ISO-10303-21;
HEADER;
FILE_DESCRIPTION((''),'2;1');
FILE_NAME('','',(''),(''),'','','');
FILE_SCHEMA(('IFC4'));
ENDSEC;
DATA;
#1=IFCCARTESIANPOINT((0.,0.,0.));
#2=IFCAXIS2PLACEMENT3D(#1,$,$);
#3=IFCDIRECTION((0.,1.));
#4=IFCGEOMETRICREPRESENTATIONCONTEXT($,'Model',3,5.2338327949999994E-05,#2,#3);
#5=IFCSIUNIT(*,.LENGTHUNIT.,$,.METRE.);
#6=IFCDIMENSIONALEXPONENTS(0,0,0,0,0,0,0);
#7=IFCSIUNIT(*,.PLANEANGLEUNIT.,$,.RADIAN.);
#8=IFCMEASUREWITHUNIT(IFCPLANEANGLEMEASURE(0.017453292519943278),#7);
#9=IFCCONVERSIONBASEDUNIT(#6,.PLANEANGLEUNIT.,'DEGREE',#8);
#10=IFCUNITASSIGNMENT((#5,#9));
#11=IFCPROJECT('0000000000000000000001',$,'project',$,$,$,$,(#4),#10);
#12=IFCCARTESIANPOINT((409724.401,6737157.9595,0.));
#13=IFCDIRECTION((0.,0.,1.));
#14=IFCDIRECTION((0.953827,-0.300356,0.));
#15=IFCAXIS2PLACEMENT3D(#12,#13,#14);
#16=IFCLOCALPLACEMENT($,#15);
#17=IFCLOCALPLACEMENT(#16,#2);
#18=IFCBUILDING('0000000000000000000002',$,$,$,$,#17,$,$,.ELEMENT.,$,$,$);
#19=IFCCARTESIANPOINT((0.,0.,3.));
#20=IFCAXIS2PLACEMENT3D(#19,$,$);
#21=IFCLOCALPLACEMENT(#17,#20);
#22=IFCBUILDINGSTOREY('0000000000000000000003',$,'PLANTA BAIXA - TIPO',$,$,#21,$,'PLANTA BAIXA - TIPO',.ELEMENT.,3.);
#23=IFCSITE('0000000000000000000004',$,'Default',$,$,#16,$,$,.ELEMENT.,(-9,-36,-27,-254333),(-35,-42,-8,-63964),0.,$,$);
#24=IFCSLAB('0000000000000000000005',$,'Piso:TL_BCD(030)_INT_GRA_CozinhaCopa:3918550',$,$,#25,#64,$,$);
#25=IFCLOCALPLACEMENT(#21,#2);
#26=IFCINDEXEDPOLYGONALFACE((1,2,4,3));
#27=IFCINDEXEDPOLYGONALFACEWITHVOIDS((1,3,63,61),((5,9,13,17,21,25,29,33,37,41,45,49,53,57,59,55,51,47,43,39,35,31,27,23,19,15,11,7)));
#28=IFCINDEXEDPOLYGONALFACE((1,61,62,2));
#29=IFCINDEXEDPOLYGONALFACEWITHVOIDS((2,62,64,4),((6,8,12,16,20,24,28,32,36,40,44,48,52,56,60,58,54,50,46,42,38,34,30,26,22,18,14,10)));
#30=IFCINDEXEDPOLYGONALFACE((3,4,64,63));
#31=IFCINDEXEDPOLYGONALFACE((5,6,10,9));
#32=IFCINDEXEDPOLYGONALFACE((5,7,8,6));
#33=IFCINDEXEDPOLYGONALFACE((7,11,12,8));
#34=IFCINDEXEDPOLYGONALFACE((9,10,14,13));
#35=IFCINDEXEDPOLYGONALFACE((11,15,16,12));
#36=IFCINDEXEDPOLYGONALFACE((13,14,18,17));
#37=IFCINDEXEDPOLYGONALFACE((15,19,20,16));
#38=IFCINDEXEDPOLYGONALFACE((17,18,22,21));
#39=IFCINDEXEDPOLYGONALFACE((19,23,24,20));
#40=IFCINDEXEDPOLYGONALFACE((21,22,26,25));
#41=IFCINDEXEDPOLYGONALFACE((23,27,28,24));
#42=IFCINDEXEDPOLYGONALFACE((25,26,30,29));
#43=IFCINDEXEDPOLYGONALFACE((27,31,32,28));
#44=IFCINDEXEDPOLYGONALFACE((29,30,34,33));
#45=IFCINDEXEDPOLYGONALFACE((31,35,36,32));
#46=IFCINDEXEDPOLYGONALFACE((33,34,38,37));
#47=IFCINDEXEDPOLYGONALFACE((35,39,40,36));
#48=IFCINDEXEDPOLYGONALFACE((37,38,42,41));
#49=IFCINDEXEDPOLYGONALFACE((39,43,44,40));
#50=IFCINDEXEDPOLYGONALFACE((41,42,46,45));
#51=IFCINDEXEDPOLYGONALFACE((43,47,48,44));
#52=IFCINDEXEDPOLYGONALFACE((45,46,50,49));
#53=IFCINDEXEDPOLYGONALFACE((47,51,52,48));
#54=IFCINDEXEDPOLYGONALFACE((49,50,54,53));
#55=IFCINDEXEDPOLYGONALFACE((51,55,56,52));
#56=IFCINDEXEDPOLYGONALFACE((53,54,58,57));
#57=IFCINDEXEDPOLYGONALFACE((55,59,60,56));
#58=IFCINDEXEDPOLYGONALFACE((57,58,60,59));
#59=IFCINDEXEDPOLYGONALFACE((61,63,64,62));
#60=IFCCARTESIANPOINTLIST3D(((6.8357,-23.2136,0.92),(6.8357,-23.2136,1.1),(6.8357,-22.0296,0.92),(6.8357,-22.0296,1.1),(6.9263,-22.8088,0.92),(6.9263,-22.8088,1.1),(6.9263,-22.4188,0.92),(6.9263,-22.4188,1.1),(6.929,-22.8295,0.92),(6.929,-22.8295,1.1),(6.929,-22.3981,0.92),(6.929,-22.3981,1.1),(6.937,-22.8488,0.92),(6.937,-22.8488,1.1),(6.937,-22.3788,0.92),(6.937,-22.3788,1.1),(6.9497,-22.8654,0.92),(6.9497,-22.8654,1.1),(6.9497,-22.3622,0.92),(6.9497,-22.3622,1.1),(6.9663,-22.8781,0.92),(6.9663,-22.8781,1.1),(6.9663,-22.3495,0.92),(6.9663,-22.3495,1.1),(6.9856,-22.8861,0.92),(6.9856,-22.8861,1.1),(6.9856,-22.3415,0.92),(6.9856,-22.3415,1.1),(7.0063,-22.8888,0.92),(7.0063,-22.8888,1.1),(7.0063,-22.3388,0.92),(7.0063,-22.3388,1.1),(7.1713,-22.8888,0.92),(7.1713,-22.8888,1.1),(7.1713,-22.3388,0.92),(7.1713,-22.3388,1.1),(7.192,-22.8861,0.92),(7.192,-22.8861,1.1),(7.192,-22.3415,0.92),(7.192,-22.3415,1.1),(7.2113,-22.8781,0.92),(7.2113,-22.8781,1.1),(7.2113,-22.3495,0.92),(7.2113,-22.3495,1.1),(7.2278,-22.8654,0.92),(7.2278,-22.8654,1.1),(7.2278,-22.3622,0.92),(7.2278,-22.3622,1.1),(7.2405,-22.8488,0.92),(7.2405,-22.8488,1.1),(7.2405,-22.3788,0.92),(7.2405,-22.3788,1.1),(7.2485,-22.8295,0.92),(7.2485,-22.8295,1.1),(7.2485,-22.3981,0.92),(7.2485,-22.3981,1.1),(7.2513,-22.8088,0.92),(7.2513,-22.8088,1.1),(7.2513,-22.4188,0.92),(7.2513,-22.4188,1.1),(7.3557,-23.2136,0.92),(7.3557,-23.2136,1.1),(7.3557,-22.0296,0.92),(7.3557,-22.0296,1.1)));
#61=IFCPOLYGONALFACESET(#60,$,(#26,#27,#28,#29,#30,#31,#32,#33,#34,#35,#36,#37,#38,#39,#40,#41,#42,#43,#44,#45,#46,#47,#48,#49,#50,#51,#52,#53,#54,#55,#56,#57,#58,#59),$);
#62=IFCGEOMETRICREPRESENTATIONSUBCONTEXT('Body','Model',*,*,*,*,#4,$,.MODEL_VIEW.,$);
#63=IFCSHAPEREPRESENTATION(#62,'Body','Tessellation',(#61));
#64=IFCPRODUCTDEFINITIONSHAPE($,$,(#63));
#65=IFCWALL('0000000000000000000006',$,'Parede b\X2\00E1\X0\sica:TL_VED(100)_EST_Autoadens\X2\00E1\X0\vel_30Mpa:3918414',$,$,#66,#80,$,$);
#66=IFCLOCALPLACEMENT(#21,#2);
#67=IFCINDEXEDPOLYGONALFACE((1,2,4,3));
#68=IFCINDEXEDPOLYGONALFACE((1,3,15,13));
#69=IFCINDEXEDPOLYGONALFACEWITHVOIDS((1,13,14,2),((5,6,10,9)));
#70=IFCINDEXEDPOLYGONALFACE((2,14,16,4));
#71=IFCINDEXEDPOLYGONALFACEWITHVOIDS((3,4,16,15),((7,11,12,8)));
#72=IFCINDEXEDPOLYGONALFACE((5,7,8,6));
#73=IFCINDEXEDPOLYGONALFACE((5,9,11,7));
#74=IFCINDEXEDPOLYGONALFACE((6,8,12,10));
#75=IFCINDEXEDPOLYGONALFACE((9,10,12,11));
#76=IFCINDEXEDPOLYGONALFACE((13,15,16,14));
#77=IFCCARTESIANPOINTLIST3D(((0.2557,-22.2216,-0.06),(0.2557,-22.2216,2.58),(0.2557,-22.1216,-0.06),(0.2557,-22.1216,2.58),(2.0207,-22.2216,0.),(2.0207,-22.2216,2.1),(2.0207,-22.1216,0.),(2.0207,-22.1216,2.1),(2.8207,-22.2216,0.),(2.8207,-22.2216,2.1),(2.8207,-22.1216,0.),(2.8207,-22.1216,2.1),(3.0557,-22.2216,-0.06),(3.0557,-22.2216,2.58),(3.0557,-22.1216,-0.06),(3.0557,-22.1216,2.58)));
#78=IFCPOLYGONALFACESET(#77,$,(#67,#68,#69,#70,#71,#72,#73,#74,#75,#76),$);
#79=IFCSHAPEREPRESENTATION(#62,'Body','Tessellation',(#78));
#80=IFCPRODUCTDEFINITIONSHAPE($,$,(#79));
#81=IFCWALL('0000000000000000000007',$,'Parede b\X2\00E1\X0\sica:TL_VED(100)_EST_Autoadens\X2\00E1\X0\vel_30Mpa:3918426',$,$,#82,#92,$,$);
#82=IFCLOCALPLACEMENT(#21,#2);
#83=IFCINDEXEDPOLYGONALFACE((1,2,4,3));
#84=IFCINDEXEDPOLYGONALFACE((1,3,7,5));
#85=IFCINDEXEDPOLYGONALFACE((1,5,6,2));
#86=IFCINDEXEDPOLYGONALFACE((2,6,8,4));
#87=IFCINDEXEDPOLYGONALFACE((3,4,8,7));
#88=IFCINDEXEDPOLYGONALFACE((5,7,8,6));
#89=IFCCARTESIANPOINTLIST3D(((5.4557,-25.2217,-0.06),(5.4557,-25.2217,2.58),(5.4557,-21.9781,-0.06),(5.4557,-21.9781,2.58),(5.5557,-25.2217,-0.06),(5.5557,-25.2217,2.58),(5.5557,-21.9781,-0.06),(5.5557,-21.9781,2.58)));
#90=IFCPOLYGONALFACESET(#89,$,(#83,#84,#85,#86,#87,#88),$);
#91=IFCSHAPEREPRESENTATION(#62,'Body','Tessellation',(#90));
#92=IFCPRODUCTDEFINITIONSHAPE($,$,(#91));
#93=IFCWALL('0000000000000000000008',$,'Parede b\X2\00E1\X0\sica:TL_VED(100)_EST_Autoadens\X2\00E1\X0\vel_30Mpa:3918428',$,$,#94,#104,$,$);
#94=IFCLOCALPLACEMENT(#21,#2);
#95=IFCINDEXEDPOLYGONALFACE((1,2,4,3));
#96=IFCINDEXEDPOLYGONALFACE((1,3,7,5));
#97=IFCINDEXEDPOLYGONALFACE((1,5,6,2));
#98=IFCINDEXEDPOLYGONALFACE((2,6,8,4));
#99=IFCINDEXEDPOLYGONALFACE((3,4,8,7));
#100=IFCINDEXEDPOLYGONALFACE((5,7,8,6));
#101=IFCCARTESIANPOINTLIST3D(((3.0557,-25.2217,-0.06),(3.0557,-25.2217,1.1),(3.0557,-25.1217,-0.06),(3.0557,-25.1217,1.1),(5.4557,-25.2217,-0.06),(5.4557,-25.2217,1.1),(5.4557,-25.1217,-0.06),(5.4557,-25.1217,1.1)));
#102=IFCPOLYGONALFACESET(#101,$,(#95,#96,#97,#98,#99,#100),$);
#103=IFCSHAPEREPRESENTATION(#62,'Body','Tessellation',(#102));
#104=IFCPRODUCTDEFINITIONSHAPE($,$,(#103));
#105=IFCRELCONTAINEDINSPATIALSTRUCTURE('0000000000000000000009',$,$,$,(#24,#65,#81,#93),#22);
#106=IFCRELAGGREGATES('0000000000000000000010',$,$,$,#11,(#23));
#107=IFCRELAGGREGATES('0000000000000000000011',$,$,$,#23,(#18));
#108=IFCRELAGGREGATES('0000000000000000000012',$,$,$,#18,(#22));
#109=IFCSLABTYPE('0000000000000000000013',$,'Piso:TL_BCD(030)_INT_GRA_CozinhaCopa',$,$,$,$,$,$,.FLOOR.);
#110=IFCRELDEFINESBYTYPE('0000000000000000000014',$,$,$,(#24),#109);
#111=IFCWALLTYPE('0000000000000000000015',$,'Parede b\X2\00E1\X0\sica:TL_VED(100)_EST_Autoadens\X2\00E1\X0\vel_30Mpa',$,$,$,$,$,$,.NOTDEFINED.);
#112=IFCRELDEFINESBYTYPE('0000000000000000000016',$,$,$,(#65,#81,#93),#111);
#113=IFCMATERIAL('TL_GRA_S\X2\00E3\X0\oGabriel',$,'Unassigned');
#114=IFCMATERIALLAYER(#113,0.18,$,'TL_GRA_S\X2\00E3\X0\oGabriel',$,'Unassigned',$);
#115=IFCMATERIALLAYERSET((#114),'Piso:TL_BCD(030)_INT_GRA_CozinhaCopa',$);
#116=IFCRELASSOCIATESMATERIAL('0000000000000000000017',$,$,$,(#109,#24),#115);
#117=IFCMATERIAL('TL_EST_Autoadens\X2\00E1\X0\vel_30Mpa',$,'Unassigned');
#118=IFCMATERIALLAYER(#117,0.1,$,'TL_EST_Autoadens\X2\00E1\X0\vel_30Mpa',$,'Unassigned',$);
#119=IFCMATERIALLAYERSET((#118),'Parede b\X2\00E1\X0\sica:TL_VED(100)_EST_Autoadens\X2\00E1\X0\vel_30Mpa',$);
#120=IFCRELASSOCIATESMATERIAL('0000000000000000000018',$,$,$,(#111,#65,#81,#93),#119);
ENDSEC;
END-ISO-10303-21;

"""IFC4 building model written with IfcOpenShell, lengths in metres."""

from ifc_helpers import new_model, entity, si_unit, converted_unit, direction, frame, frame_2d, origin, origin_2d_with_axis, place, context, subcontext, project, spatial, polyline, circle_curve, parameter, trimmed, segment, composite_curve, rectangle, outline, extrude, material, layer, layer_set, layer_usage, type_object, element, save


model = new_model("IFC4")

# Units and contexts
model_context = context("Model", 3, precision=5.2338327949999994e-05, world=origin(), true_north=direction((0.0, 1.0)))
body_context = subcontext(model_context, "Body", "Model", "MODEL_VIEW")
ifc_project = project(units=[si_unit("LENGTHUNIT", "METRE"), converted_unit("PLANEANGLEUNIT", "DEGREE", entity("IfcPlaneAngleMeasure", 0.017453292519943278), si_unit("PLANEANGLEUNIT", "RADIAN"), dimensions=[0, 0, 0, 0, 0, 0, 0])], contexts=[model_context])

# Site, building, storey
site_placement = place(None, frame((409724.401, 6737157.9595, 0.0), z_axis=(0.0, 0.0, 1.0), x_axis=(0.953827, -0.300356, 0.0)))
site = spatial("IfcSite", under=ifc_project, at=site_placement, Name="Default", CompositionType="ELEMENT", RefLatitude=(-9, -36, -27, -254333), RefLongitude=(-35, -42, -8, -63964), RefElevation=0.0)
building_placement = place(site_placement, origin())
building = spatial("IfcBuilding", under=site, at=building_placement, CompositionType="ELEMENT")
storey_placement = place(building_placement, frame((0.0, 0.0, 3.0)))
storey = spatial("IfcBuildingStorey", under=building, at=storey_placement, Name="PLANTA BAIXA - TIPO", LongName="PLANTA BAIXA - TIPO", CompositionType="ELEMENT", Elevation=3.0)

# Slab, opening
ifc_material_1 = material(Name="TL_GRA_SãoGabriel", Category="Unassigned")
ifc_layer_1 = layer(ifc_material_1, 0.18, Name="TL_GRA_SãoGabriel", Category="Unassigned")
ifc_layer_set_1 = layer_set([ifc_layer_1], Name="Piso:TL_BCD(030)_INT_GRA_CozinhaCopa")
ifc_layer_usage_1 = layer_usage(ifc_layer_set_1, "AXIS3", "POSITIVE", 0.0)
slab_type = type_object("IfcSlabType", Name="Piso:TL_BCD(030)_INT_GRA_CozinhaCopa", PredefinedType="FLOOR", material=ifc_layer_set_1)
slab_placement = place(storey_placement, frame((6.8357, -23.2136, 0.92)))
slab = element("IfcSlab", 1, at=slab_placement, inside=storey, type_object=slab_type, material=ifc_layer_usage_1, Name="Piso:TL_BCD(030)_INT_GRA_CozinhaCopa:3918550", context=body_context, shape_type="SweptSolid", body=[
    extrude(rectangle(XDim=0.52, YDim=1.184, at=origin_2d_with_axis()), frame((0.26, 0.592, 0.18), z_axis=(0.0, 0.0, -1.0), x_axis=(-1.0, 0.0, 0.0)), (0.0, 0.0, 1.0), 0.18),
])
opening_1_placement = place(slab_placement, frame((-6.8357, 23.2136, 0.18)))
element("IfcOpeningElement", 2, at=opening_1_placement, cuts=slab, PredefinedType="OPENING", context=body_context, shape_type="SweptSolid", body=[
    extrude(outline(composite_curve([segment(trimmed(circle_curve(frame_2d((0.195, -0.0825), x_axis=(1.0, 0.0)), 0.08), [parameter(270.0)], [parameter(0.0)], True, "PARAMETER"), True, "CONTINUOUS"), segment(polyline([(0.275, -0.0825), (0.275, 0.0825)]), True, "CONTINUOUS"), segment(trimmed(circle_curve(frame_2d((0.195, 0.0825), x_axis=(1.0, 0.0)), 0.08), [parameter(0.0)], [parameter(90.0)], True, "PARAMETER"), True, "CONTINUOUS"), segment(polyline([(0.195, 0.1625), (-0.195, 0.1625)]), True, "CONTINUOUS"), segment(trimmed(circle_curve(frame_2d((-0.195, 0.0825), x_axis=(1.0, 0.0)), 0.08), [parameter(90.0)], [parameter(180.0)], True, "PARAMETER"), True, "CONTINUOUS"), segment(polyline([(-0.275, 0.0825), (-0.275, -0.0825)]), True, "CONTINUOUS"), segment(trimmed(circle_curve(frame_2d((-0.195, -0.0825), x_axis=(1.0, 0.0)), 0.08), [parameter(180.0)], [parameter(270.0)], True, "PARAMETER"), True, "CONTINUOUS"), segment(polyline([(-0.195, -0.1625), (0.195, -0.1625)]), True, "CONTINUOUS")], self_intersect=False)), frame((7.0888, -22.6138, -0.21), z_axis=(0.0, 0.0, 1.0), x_axis=(0.0, 1.0, 0.0)), (0.0, 0.0, 1.0), 0.21),
])

# Wall, opening
ifc_material_2 = material(Name="TL_EST_Autoadensável_30Mpa", Category="Unassigned")
ifc_layer_2 = layer(ifc_material_2, 0.1, Name="TL_EST_Autoadensável_30Mpa", Category="Unassigned")
ifc_layer_set_2 = layer_set([ifc_layer_2], Name="Parede básica:TL_VED(100)_EST_Autoadensável_30Mpa")
ifc_layer_usage_2 = layer_usage(ifc_layer_set_2, "AXIS2", "NEGATIVE", 0.05)
wall_type_1 = type_object("IfcWallType", Name="Parede básica:TL_VED(100)_EST_Autoadensável_30Mpa", PredefinedType="NOTDEFINED", material=ifc_layer_set_2)
wall_1_placement = place(storey_placement, frame((3.0557, -22.1716, -0.06), z_axis=(0.0, 0.0, 1.0), x_axis=(-1.0, 0.0, 0.0)))
wall_1 = element("IfcWall", 3, at=wall_1_placement, inside=storey, type_object=wall_type_1, material=ifc_layer_usage_2, Name="Parede básica:TL_VED(100)_EST_Autoadensável_30Mpa:3918414", context=body_context, shape_type="SweptSolid", body=[
    extrude(rectangle(XDim=2.8, YDim=0.1, at=frame_2d((1.4, 0.0), x_axis=(-1.0, 0.0))), origin(), (0.0, 0.0, 1.0), 2.64),
])
opening_2_placement = place(wall_1_placement, frame((0.235, -0.05, 0.06)))
element("IfcOpeningElement", 4, at=opening_2_placement, cuts=wall_1, PredefinedType="OPENING", context=body_context, shape_type="SweptSolid", body=[
    extrude(rectangle(XDim=2.1, YDim=0.8, at=frame_2d((1.05, 0.4), x_axis=(1.0, 0.0))), frame((0.0, 0.0, 0.0), z_axis=(0.0, 1.0, 0.0), x_axis=(0.0, 0.0, 1.0)), (0.0, 0.0, 1.0), 0.1),
])

# Walls
ifc_layer_usage_3 = layer_usage(ifc_layer_set_2, "AXIS2", "POSITIVE", -0.05)
wall_2_placement = place(storey_placement, frame((5.5057, -25.2217, -0.06), z_axis=(0.0, 0.0, 1.0), x_axis=(0.0, 1.0, 0.0)))
element("IfcWall", 5, at=wall_2_placement, inside=storey, type_object=wall_type_1, material=ifc_layer_usage_3, Name="Parede básica:TL_VED(100)_EST_Autoadensável_30Mpa:3918426", context=body_context, shape_type="SweptSolid", body=[
    extrude(rectangle(XDim=3.2437, YDim=0.1, at=frame_2d((1.6218, 0.0), x_axis=(-1.0, 0.0))), origin(), (0.0, 0.0, 1.0), 2.64),
])
ifc_layer_usage_4 = layer_usage(ifc_layer_set_2, "AXIS2", "POSITIVE", -0.05)
wall_3_placement = place(storey_placement, frame((3.0557, -25.1717, -0.06)))
element("IfcWall", 6, at=wall_3_placement, inside=storey, type_object=wall_type_1, material=ifc_layer_usage_4, Name="Parede básica:TL_VED(100)_EST_Autoadensável_30Mpa:3918428", context=body_context, shape_type="SweptSolid", body=[
    extrude(rectangle(XDim=2.4, YDim=0.1, at=frame_2d((1.2, 0.0), x_axis=(-1.0, 0.0))), origin(), (0.0, 0.0, 1.0), 1.16),
])

save(model, "model.ifc")
